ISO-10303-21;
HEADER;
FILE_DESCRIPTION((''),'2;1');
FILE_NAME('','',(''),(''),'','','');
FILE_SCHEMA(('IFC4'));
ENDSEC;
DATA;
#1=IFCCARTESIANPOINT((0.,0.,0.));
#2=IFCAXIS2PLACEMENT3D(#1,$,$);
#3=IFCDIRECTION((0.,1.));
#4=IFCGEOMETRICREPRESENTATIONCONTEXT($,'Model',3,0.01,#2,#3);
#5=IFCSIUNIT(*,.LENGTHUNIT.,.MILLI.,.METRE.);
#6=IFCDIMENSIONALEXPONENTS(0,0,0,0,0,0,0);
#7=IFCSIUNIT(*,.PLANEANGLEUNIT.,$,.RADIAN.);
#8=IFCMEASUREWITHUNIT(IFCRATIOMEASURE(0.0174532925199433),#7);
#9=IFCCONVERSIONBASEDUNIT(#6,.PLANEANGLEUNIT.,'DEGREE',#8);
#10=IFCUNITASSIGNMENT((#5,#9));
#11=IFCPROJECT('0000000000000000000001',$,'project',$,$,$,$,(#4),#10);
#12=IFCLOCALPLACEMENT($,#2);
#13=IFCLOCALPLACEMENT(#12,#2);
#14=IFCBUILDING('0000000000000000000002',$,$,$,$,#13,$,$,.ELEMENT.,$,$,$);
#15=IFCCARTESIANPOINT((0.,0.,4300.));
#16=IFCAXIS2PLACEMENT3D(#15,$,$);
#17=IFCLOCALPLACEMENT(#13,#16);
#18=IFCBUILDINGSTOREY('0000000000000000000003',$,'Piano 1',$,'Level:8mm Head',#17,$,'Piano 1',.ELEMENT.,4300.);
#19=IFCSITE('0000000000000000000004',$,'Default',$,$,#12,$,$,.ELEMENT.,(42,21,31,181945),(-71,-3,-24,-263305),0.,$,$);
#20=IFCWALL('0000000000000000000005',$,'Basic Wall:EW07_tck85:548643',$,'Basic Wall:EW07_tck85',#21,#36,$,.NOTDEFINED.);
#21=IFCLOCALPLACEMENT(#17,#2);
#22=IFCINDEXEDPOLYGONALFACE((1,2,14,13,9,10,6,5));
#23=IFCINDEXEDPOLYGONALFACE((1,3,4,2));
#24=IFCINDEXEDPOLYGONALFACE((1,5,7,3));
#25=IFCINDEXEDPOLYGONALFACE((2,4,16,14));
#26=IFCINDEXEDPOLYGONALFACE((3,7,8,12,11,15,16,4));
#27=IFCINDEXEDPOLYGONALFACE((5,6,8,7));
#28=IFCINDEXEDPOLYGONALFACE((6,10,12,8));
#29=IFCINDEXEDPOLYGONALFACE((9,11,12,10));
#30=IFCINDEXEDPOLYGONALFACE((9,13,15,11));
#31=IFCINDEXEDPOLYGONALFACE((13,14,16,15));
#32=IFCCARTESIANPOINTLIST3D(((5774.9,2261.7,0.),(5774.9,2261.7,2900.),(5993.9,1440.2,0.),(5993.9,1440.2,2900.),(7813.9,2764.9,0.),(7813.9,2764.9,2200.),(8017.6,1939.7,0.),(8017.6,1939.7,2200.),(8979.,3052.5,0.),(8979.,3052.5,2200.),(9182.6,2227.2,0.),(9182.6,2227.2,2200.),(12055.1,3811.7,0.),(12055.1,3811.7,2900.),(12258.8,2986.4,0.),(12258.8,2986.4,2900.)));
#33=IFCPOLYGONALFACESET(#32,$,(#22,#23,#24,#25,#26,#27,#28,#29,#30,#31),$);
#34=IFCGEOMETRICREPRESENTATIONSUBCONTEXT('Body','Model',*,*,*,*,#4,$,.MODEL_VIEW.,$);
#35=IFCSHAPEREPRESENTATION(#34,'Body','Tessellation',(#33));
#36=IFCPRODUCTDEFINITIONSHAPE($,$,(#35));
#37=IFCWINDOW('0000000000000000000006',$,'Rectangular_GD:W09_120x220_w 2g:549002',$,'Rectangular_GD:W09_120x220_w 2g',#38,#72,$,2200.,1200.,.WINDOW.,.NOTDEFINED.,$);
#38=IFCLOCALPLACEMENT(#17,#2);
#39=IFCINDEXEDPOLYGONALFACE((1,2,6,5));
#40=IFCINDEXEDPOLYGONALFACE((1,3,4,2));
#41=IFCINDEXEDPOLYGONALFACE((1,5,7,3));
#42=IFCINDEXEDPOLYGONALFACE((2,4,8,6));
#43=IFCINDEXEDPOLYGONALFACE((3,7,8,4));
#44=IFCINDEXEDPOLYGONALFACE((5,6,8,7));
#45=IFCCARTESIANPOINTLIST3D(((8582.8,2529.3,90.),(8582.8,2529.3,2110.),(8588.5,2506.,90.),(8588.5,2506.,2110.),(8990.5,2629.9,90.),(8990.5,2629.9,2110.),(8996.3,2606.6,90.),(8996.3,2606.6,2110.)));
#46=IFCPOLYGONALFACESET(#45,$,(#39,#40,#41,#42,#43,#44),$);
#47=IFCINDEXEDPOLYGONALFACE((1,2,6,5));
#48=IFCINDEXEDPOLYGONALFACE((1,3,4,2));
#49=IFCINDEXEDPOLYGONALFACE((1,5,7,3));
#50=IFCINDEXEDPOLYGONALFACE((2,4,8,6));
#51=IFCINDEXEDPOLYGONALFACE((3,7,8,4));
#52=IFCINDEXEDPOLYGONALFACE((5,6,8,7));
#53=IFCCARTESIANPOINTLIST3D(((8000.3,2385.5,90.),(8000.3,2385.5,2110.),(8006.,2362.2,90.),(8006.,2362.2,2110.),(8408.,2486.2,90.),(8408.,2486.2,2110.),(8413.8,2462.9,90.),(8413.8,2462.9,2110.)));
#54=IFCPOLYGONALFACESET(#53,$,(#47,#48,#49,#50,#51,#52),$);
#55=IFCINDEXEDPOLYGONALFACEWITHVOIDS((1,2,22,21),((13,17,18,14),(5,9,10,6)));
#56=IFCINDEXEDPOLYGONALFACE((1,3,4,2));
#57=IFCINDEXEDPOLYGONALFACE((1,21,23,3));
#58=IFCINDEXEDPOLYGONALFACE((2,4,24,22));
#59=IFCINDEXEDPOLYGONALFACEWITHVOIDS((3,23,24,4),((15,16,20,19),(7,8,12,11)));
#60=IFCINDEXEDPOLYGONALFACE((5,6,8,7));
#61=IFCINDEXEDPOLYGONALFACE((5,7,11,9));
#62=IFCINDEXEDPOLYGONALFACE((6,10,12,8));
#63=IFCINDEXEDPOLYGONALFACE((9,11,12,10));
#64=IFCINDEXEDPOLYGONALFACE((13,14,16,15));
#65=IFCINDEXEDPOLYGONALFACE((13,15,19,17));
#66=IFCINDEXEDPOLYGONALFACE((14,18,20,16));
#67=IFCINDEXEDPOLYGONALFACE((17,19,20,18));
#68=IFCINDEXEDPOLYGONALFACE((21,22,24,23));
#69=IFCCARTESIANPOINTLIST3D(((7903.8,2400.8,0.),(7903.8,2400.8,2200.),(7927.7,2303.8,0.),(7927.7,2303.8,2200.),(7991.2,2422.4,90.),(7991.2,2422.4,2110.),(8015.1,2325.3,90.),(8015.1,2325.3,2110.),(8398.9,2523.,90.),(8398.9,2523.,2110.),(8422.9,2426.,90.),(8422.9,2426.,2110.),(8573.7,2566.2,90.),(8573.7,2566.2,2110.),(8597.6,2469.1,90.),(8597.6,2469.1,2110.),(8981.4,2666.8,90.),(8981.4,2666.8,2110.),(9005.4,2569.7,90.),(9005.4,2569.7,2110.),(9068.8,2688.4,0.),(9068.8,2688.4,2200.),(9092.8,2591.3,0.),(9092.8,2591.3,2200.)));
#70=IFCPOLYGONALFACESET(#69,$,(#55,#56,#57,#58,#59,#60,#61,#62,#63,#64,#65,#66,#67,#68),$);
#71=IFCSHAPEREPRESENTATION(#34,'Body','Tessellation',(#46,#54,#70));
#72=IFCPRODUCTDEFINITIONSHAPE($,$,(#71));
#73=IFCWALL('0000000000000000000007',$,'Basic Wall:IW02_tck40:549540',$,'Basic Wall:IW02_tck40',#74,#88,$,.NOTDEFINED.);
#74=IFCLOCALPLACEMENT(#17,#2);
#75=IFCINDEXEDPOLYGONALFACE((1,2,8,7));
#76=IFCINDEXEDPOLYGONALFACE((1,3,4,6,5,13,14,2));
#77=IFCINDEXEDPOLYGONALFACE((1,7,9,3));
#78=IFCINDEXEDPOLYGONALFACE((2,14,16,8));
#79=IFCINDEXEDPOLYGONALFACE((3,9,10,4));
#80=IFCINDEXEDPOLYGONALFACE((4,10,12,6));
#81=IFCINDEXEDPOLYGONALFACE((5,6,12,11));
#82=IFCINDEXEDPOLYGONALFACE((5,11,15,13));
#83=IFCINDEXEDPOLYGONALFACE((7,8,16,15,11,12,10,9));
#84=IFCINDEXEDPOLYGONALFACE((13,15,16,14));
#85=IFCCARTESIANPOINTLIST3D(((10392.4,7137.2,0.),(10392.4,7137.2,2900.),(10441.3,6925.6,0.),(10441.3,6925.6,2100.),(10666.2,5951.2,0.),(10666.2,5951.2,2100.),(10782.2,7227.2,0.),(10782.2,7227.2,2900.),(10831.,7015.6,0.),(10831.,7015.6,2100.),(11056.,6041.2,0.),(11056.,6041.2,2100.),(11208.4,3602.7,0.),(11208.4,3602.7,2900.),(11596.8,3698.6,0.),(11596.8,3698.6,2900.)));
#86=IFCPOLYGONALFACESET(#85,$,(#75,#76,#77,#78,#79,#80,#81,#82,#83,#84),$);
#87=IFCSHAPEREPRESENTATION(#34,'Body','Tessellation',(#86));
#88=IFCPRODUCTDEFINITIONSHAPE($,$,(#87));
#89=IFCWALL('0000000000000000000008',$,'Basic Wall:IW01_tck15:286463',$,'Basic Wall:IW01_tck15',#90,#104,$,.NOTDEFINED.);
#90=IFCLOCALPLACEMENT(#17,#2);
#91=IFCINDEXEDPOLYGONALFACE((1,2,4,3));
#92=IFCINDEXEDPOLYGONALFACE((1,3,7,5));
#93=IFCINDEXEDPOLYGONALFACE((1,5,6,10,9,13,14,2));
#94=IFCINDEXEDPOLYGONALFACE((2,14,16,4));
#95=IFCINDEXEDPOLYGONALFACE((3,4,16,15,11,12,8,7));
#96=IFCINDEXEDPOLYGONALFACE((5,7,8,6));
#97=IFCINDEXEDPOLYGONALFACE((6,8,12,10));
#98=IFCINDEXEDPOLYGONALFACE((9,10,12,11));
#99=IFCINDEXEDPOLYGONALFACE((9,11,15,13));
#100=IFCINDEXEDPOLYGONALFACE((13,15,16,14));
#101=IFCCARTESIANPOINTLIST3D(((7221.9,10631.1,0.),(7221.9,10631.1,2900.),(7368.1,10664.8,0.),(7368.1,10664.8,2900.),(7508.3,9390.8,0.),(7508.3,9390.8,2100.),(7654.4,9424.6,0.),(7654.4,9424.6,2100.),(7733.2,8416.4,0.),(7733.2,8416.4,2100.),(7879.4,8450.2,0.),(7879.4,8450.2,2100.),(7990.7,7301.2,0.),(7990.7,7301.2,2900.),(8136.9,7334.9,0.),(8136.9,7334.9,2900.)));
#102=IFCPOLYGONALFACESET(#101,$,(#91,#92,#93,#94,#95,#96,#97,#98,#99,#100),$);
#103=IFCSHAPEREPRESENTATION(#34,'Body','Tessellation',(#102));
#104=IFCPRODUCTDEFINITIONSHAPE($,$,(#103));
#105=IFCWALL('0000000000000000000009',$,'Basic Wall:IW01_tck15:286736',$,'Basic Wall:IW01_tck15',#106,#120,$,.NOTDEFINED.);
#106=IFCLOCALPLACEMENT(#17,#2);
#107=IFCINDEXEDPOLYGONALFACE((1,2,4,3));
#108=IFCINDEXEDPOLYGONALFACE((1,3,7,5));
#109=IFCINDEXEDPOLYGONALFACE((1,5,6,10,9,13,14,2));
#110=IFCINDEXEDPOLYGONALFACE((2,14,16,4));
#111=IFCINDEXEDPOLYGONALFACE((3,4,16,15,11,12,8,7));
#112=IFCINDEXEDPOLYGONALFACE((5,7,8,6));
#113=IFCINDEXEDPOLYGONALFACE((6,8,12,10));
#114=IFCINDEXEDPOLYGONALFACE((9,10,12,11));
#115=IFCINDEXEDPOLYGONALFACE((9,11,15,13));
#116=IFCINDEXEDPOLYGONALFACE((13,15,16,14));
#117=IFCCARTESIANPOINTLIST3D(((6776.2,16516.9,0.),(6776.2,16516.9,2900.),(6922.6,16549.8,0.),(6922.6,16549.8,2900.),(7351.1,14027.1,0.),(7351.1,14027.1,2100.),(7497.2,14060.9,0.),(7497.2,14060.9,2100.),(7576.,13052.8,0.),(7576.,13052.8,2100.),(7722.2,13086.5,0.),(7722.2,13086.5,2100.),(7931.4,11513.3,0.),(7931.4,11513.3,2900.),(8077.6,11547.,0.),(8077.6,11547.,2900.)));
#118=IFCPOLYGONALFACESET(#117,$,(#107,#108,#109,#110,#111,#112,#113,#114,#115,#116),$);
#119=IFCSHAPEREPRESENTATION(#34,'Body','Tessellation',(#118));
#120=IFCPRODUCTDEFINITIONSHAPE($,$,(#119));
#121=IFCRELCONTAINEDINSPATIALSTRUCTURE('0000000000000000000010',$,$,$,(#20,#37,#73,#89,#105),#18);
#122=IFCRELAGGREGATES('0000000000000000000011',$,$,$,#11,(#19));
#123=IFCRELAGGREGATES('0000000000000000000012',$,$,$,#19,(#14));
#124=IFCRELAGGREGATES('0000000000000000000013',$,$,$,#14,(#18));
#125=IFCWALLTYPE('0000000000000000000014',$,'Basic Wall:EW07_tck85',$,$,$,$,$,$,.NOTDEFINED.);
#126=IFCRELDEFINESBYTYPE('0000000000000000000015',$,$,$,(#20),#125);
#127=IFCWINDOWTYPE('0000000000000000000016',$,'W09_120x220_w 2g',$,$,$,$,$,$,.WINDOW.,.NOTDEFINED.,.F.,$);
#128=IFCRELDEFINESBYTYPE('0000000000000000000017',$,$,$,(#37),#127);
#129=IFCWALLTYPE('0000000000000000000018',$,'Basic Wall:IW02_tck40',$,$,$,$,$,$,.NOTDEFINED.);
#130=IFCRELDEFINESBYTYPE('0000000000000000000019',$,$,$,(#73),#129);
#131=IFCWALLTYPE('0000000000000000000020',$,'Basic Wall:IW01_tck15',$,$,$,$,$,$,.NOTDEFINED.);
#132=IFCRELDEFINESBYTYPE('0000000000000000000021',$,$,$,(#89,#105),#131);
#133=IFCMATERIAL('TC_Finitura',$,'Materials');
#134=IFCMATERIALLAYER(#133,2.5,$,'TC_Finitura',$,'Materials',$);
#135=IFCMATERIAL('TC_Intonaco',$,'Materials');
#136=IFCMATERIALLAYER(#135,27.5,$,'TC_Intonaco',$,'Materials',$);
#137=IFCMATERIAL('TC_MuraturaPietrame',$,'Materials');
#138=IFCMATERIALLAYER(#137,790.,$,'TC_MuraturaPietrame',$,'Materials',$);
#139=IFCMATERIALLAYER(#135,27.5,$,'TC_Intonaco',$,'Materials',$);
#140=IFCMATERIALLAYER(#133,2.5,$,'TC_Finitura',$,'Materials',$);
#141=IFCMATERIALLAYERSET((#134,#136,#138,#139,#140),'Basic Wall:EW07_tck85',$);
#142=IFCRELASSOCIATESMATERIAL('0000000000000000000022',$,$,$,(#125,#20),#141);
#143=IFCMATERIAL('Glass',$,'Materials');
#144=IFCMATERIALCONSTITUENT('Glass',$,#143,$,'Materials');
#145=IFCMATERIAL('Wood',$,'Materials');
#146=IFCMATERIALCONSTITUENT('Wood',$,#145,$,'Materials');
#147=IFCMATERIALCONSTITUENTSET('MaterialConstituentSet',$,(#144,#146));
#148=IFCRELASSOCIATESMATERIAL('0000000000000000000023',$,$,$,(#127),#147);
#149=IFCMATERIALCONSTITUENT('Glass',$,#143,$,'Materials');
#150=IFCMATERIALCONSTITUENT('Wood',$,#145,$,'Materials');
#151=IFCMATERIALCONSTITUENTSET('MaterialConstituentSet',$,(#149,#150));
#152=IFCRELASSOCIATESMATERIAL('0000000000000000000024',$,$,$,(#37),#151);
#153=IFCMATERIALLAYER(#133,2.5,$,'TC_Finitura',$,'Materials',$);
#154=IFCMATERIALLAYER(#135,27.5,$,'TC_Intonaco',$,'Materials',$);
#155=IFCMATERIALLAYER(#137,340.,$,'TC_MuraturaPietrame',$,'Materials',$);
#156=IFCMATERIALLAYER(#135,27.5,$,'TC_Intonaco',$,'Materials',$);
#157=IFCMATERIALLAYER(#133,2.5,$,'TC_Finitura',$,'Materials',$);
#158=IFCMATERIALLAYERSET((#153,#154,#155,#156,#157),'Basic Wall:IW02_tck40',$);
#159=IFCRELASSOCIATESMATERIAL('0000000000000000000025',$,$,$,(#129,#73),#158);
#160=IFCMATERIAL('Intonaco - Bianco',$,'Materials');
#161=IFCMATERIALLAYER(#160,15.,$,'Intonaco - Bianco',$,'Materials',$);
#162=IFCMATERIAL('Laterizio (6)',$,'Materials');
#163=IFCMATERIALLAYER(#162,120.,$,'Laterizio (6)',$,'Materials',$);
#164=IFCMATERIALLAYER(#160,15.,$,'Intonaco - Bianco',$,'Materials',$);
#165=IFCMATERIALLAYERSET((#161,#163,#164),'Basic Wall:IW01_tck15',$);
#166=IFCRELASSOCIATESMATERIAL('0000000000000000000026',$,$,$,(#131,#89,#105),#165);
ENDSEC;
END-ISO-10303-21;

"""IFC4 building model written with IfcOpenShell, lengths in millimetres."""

from ifc_helpers import new_model, entity, si_unit, converted_unit, direction, frame, frame_2d, origin, origin_2d_with_axis, place, context, subcontext, project, spatial, polyline, rectangle, outline, extrude, clip, bounded_halfspace, source, transform, mapped, material, layer, layer_set, layer_usage, constituent, constituent_set, type_object, type_shapes, element, fill, save


model = new_model("IFC4")

# Units and contexts
model_context = context("Model", 3, precision=0.01, world=origin(), true_north=direction((0.0, 1.0)))
body_context = subcontext(model_context, "Body", "Model", "MODEL_VIEW")
ifc_project = project(units=[si_unit("LENGTHUNIT", "METRE", prefix="MILLI"), converted_unit("PLANEANGLEUNIT", "DEGREE", entity("IfcRatioMeasure", 0.0174532925199433), si_unit("PLANEANGLEUNIT", "RADIAN"), dimensions=[0, 0, 0, 0, 0, 0, 0])], contexts=[model_context])

# Site, building, storey
site_placement = place(None, origin())
site = spatial("IfcSite", under=ifc_project, at=site_placement, Name="Default", CompositionType="ELEMENT", RefLatitude=(42, 21, 31, 181945), RefLongitude=(-71, -3, -24, -263305), RefElevation=0.0)
building_placement = place(site_placement, origin())
building = spatial("IfcBuilding", under=site, at=building_placement, CompositionType="ELEMENT")
storey_placement = place(building_placement, frame((0.0, 0.0, 4300.0)))
storey = spatial("IfcBuildingStorey", under=building, at=storey_placement, Name="Piano 1", ObjectType="Level:8mm Head", LongName="Piano 1", CompositionType="ELEMENT", Elevation=4300.0)

# Shared definitions
ifc_material_1 = material(Name="TC_Finitura", Category="Materials")
ifc_material_2 = material(Name="TC_Intonaco", Category="Materials")
ifc_material_3 = material(Name="TC_MuraturaPietrame", Category="Materials")
ifc_material_4 = material(Name="Glass", Category="Materials")
ifc_material_5 = material(Name="Wood", Category="Materials")

# Wall, opening, window
ifc_layer_1 = layer(ifc_material_1, 2.5, Name="TC_Finitura", Category="Materials")
ifc_layer_2 = layer(ifc_material_2, 27.5, Name="TC_Intonaco", Category="Materials")
ifc_layer_3 = layer(ifc_material_3, 790.0, Name="TC_MuraturaPietrame", Category="Materials")
ifc_layer_4 = layer(ifc_material_2, 27.5, Name="TC_Intonaco", Category="Materials")
ifc_layer_5 = layer(ifc_material_1, 2.5, Name="TC_Finitura", Category="Materials")
ifc_layer_set_1 = layer_set([ifc_layer_1, ifc_layer_2, ifc_layer_3, ifc_layer_4, ifc_layer_5], Name="Basic Wall:EW07_tck85")
ifc_layer_usage_1 = layer_usage(ifc_layer_set_1, "AXIS2", "POSITIVE", -425.0)
wall_type_1 = type_object("IfcWallType", Name="Basic Wall:EW07_tck85", PredefinedType="NOTDEFINED", material=ifc_layer_set_1)
wall_1_placement = place(storey_placement, frame((5876.7, 1849.0, 0.0), z_axis=(0.0, 0.0, 1.0), x_axis=(0.970868, 0.239617, 0.0)))
wall_1 = element("IfcWall", 1, at=wall_1_placement, inside=storey, type_object=wall_type_1, material=ifc_layer_usage_1, Name="Basic Wall:EW07_tck85:548643", ObjectType="Basic Wall:EW07_tck85", PredefinedType="NOTDEFINED", context=body_context, shape_type="Clipping", body=[
    clip(extrude(outline(polyline([(15.9, -425.0), (6468.7, -425.0), (6468.7, 375.0), (6468.7, 425.0), (5996.7, 425.0), (5596.6, 425.0), (0.0, 425.0), (15.9, -425.0)])), origin(), (0.0, 0.0, 1.0), 2900.0), bounded_halfspace(frame((15.9, -425.0, 2900.0), z_axis=(0.0, 0.0, -1.0), x_axis=(0.999481, 0.032214, 0.0)), True, frame((15.9, -425.0, 2900.0)), polyline([(0.0, 0.0), (6452.9, 0.0), (6452.9, 800.0), (6452.9, 850.0), (5980.8, 850.0), (5580.8, 850.0), (-15.9, 850.0), (0.0, 0.0)]))),
])
opening_1_placement = place(wall_1_placement, frame((3300.3, 425.0, 0.0)))
opening_1 = element("IfcOpeningElement", 2, at=opening_1_placement, cuts=wall_1, ObjectType="Opening", PredefinedType="OPENING", context=body_context, shape_type="SweptSolid", body=[
    extrude(rectangle(XDim=2200.0, YDim=1200.0, at=frame_2d((1100.0, 600.0), x_axis=(-1.0, 0.0))), frame((0.0, 0.0, 0.0), z_axis=(0.0, -1.0, 0.0), x_axis=(0.0, 0.0, 1.0)), (0.0, 0.0, 1.0), 850.0),
])
ifc_constituent_1 = constituent(ifc_material_4, Name="Glass", Category="Materials")
ifc_constituent_2 = constituent(ifc_material_5, Name="Wood", Category="Materials")
ifc_constituent_set_1 = constituent_set(constituents=[ifc_constituent_1, ifc_constituent_2], Name="MaterialConstituentSet")
ifc_constituent_3 = constituent(ifc_material_4, Name="Glass", Category="Materials")
ifc_constituent_4 = constituent(ifc_material_5, Name="Wood", Category="Materials")
ifc_constituent_set_2 = constituent_set(constituents=[ifc_constituent_3, ifc_constituent_4], Name="MaterialConstituentSet")
window_type_1 = type_object("IfcWindowType", Name="W09_120x220_w 2g", ParameterTakesPrecedence=False, PartitioningType="NOTDEFINED", PredefinedType="WINDOW", material=ifc_constituent_set_2)
shared_shape_1 = source(origin(), body_context, "Body", "SweptSolid", [
    extrude(rectangle(XDim=24.0, YDim=420.0, at=frame_2d((0.0, 0.0), x_axis=(1.0, 0.0))), frame((300.0, 425.0, 90.0), z_axis=(0.0, 0.0, 1.0), x_axis=(0.0, 1.0, 0.0)), (0.0, 0.0, 1.0), 2020.0),
    extrude(rectangle(XDim=24.0, YDim=420.0, at=origin_2d_with_axis()), frame((900.0, 425.0, 90.0), z_axis=(0.0, 0.0, 1.0), x_axis=(0.0, 1.0, 0.0)), (0.0, 0.0, 1.0), 2020.0),
    extrude(outline(polyline([(-600.0, -1100.0), (600.0, -1100.0), (600.0, 1100.0), (-600.0, 1100.0), (-600.0, -1100.0)]), holes=[polyline([(-510.0, 1010.0), (-90.0, 1010.0), (-90.0, -1010.0), (-510.0, -1010.0), (-510.0, 1010.0)]), polyline([(90.0, -1010.0), (90.0, 1010.0), (510.0, 1010.0), (510.0, -1010.0), (90.0, -1010.0)])]), frame((600.0, 375.0, 1100.0), z_axis=(0.0, 1.0, 0.0), x_axis=(1.0, 0.0, 0.0)), (0.0, 0.0, 1.0), 100.0),
])
type_shapes(window_type_1, [shared_shape_1])
window_1_placement = place(opening_1_placement, frame((0.0, 0.0, 0.0), z_axis=(0.0, 0.0, 1.0), x_axis=(-1.0, 0.0, 0.0)))
window_1 = element("IfcWindow", 3, at=window_1_placement, inside=storey, type_object=window_type_1, material=ifc_constituent_set_1, Name="Rectangular_GD:W09_120x220_w 2g:549002", ObjectType="Rectangular_GD:W09_120x220_w 2g", OverallHeight=2200.0, OverallWidth=1200.0, PartitioningType="NOTDEFINED", PredefinedType="WINDOW", context=body_context, shape_type="MappedRepresentation", body=[
    mapped(shared_shape_1, transform((0.0, 0.0, 0.0), scale=1.0)),
])
fill(opening_1, window_1)

# Wall, opening
ifc_layer_6 = layer(ifc_material_1, 2.5, Name="TC_Finitura", Category="Materials")
ifc_layer_7 = layer(ifc_material_2, 27.5, Name="TC_Intonaco", Category="Materials")
ifc_layer_8 = layer(ifc_material_3, 340.0, Name="TC_MuraturaPietrame", Category="Materials")
ifc_layer_9 = layer(ifc_material_2, 27.5, Name="TC_Intonaco", Category="Materials")
ifc_layer_10 = layer(ifc_material_1, 2.5, Name="TC_Finitura", Category="Materials")
ifc_layer_set_2 = layer_set([ifc_layer_6, ifc_layer_7, ifc_layer_8, ifc_layer_9, ifc_layer_10], Name="Basic Wall:IW02_tck40")
ifc_layer_usage_2 = layer_usage(ifc_layer_set_2, "AXIS2", "NEGATIVE", 200.0)
wall_type_2 = type_object("IfcWallType", Name="Basic Wall:IW02_tck40", PredefinedType="NOTDEFINED", material=ifc_layer_set_2)
wall_2_placement = place(storey_placement, frame((10587.3, 7182.2, 0.0), z_axis=(0.0, 0.0, 1.0), x_axis=(0.224951, -0.97437, 0.0)))
wall_2 = element("IfcWall", 4, at=wall_2_placement, inside=storey, type_object=wall_type_2, material=ifc_layer_usage_2, Name="Basic Wall:IW02_tck40:549540", ObjectType="Basic Wall:IW02_tck40", PredefinedType="NOTDEFINED", context=body_context, shape_type="Clipping", body=[
    clip(extrude(outline(polyline([(0.0, -200.0), (3627.5, -200.0), (3621.5, 200.0), (1478.3, 200.0), (1328.3, 200.0), (0.0, 200.0), (0.0, -54.3), (0.0, -200.0)])), origin(), (0.0, 0.0, 1.0), 2900.0), bounded_halfspace(frame((0.0, -200.0, 2900.0), z_axis=(0.0, 0.0, -1.0), x_axis=(-0.04728, 0.998882, 0.0)), True, frame((0.0, -200.0, 2900.0)), polyline([(0.0, 0.0), (3627.5, 0.0), (3621.5, 400.0), (1478.3, 400.0), (1328.3, 400.0), (0.0, 400.0), (0.0, 145.7), (0.0, 0.0)]))),
])
opening_2_placement = place(wall_2_placement, frame((217.2, -200.0, 0.0)))
element("IfcOpeningElement", 5, at=opening_2_placement, cuts=wall_2, ObjectType="Opening", PredefinedType="OPENING", context=body_context, shape_type="SweptSolid", body=[
    extrude(rectangle(XDim=2100.0, YDim=1000.0, at=frame_2d((1050.0, 500.0), x_axis=(1.0, 0.0))), frame((0.0, 0.0, 0.0), z_axis=(0.0, 1.0, 0.0), x_axis=(0.0, 0.0, 1.0)), (0.0, 0.0, 1.0), 400.0),
])

# Walls, openings
ifc_material_6 = material(Name="Intonaco - Bianco", Category="Materials")
ifc_layer_11 = layer(ifc_material_6, 15.0, Name="Intonaco - Bianco", Category="Materials")
ifc_material_7 = material(Name="Laterizio (6)", Category="Materials")
ifc_layer_12 = layer(ifc_material_7, 120.0, Name="Laterizio (6)", Category="Materials")
ifc_layer_13 = layer(ifc_material_6, 15.0, Name="Intonaco - Bianco", Category="Materials")
ifc_layer_set_3 = layer_set([ifc_layer_11, ifc_layer_12, ifc_layer_13], Name="Basic Wall:IW01_tck15")
ifc_layer_usage_3 = layer_usage(ifc_layer_set_3, "AXIS2", "NEGATIVE", 75.0)
wall_type_3 = type_object("IfcWallType", Name="Basic Wall:IW01_tck15", PredefinedType="NOTDEFINED", material=ifc_layer_set_3)
wall_3_placement = place(storey_placement, frame((7295.0, 10647.9, 0.0), z_axis=(0.0, 0.0, 1.0), x_axis=(0.224951, -0.97437, 0.0)))
wall_3 = element("IfcWall", 6, at=wall_3_placement, inside=storey, type_object=wall_type_3, material=ifc_layer_usage_3, Name="Basic Wall:IW01_tck15:286463", ObjectType="Basic Wall:IW01_tck15", PredefinedType="NOTDEFINED", context=body_context, shape_type="Clipping", body=[
    clip(extrude(rectangle(XDim=3417.5, YDim=150.0, at=frame_2d((1708.7, 0.0), x_axis=(-1.0, 0.0))), origin(), (0.0, 0.0, 1.0), 2900.0), bounded_halfspace(frame((0.0, -75.0, 2900.0), z_axis=(0.0, 0.0, -1.0), x_axis=(-0.04728, 0.998882, 0.0)), True, frame((0.0, -75.0, 2900.0)), polyline([(0.0, 0.0), (3417.5, 0.0), (3417.5, 150.0), (0.0, 150.0), (0.0, 0.0)]))),
])
opening_3_placement = place(wall_3_placement, frame((2272.9, 75.0, 0.0)))
element("IfcOpeningElement", 7, at=opening_3_placement, cuts=wall_3, ObjectType="Opening", PredefinedType="OPENING", context=body_context, shape_type="SweptSolid", body=[
    extrude(rectangle(XDim=2100.0, YDim=1000.0, at=frame_2d((1050.0, 500.0), x_axis=(1.0, 0.0))), frame((0.0, 0.0, 0.0), z_axis=(0.0, -1.0, 0.0), x_axis=(0.0, 0.0, 1.0)), (0.0, 0.0, 1.0), 150.0),
])
ifc_layer_usage_4 = layer_usage(ifc_layer_set_3, "AXIS2", "NEGATIVE", 75.0)
wall_4_placement = place(storey_placement, frame((8004.5, 11530.1, 0.0), z_axis=(0.0, 0.0, 1.0), x_axis=(-0.224951, 0.97437, 0.0)))
wall_4 = element("IfcWall", 8, at=wall_4_placement, inside=storey, type_object=wall_type_3, material=ifc_layer_usage_4, Name="Basic Wall:IW01_tck15:286736", ObjectType="Basic Wall:IW01_tck15", PredefinedType="NOTDEFINED", context=body_context, shape_type="Clipping", body=[
    clip(extrude(outline(polyline([(0.0, -75.0), (2884.1, -75.0), (3034.1, -75.0), (5134.4, -75.0), (5135.3, 75.0), (0.0, 75.0), (0.0, -75.0)])), origin(), (0.0, 0.0, 1.0), 2900.0), bounded_halfspace(frame((0.0, -75.0, 2900.0), z_axis=(0.0, 0.0, -1.0), x_axis=(0.04728, -0.998882, 0.0)), True, frame((0.0, -75.0, 2900.0)), polyline([(0.0, 0.0), (2884.1, 0.0), (3034.1, 0.0), (5134.4, 0.0), (5135.3, 150.0), (0.0, 150.0), (0.0, 0.0)]))),
])
opening_4_placement = place(wall_4_placement, frame((1580.0, -75.0, 0.0)))
element("IfcOpeningElement", 9, at=opening_4_placement, cuts=wall_4, ObjectType="Opening", PredefinedType="OPENING", context=body_context, shape_type="SweptSolid", body=[
    extrude(rectangle(XDim=2100.0, YDim=1000.0, at=frame_2d((1050.0, 500.0), x_axis=(1.0, 0.0))), frame((0.0, 0.0, 0.0), z_axis=(0.0, 1.0, 0.0), x_axis=(0.0, 0.0, 1.0)), (0.0, 0.0, 1.0), 150.0),
])

save(model, "model.ifc")
